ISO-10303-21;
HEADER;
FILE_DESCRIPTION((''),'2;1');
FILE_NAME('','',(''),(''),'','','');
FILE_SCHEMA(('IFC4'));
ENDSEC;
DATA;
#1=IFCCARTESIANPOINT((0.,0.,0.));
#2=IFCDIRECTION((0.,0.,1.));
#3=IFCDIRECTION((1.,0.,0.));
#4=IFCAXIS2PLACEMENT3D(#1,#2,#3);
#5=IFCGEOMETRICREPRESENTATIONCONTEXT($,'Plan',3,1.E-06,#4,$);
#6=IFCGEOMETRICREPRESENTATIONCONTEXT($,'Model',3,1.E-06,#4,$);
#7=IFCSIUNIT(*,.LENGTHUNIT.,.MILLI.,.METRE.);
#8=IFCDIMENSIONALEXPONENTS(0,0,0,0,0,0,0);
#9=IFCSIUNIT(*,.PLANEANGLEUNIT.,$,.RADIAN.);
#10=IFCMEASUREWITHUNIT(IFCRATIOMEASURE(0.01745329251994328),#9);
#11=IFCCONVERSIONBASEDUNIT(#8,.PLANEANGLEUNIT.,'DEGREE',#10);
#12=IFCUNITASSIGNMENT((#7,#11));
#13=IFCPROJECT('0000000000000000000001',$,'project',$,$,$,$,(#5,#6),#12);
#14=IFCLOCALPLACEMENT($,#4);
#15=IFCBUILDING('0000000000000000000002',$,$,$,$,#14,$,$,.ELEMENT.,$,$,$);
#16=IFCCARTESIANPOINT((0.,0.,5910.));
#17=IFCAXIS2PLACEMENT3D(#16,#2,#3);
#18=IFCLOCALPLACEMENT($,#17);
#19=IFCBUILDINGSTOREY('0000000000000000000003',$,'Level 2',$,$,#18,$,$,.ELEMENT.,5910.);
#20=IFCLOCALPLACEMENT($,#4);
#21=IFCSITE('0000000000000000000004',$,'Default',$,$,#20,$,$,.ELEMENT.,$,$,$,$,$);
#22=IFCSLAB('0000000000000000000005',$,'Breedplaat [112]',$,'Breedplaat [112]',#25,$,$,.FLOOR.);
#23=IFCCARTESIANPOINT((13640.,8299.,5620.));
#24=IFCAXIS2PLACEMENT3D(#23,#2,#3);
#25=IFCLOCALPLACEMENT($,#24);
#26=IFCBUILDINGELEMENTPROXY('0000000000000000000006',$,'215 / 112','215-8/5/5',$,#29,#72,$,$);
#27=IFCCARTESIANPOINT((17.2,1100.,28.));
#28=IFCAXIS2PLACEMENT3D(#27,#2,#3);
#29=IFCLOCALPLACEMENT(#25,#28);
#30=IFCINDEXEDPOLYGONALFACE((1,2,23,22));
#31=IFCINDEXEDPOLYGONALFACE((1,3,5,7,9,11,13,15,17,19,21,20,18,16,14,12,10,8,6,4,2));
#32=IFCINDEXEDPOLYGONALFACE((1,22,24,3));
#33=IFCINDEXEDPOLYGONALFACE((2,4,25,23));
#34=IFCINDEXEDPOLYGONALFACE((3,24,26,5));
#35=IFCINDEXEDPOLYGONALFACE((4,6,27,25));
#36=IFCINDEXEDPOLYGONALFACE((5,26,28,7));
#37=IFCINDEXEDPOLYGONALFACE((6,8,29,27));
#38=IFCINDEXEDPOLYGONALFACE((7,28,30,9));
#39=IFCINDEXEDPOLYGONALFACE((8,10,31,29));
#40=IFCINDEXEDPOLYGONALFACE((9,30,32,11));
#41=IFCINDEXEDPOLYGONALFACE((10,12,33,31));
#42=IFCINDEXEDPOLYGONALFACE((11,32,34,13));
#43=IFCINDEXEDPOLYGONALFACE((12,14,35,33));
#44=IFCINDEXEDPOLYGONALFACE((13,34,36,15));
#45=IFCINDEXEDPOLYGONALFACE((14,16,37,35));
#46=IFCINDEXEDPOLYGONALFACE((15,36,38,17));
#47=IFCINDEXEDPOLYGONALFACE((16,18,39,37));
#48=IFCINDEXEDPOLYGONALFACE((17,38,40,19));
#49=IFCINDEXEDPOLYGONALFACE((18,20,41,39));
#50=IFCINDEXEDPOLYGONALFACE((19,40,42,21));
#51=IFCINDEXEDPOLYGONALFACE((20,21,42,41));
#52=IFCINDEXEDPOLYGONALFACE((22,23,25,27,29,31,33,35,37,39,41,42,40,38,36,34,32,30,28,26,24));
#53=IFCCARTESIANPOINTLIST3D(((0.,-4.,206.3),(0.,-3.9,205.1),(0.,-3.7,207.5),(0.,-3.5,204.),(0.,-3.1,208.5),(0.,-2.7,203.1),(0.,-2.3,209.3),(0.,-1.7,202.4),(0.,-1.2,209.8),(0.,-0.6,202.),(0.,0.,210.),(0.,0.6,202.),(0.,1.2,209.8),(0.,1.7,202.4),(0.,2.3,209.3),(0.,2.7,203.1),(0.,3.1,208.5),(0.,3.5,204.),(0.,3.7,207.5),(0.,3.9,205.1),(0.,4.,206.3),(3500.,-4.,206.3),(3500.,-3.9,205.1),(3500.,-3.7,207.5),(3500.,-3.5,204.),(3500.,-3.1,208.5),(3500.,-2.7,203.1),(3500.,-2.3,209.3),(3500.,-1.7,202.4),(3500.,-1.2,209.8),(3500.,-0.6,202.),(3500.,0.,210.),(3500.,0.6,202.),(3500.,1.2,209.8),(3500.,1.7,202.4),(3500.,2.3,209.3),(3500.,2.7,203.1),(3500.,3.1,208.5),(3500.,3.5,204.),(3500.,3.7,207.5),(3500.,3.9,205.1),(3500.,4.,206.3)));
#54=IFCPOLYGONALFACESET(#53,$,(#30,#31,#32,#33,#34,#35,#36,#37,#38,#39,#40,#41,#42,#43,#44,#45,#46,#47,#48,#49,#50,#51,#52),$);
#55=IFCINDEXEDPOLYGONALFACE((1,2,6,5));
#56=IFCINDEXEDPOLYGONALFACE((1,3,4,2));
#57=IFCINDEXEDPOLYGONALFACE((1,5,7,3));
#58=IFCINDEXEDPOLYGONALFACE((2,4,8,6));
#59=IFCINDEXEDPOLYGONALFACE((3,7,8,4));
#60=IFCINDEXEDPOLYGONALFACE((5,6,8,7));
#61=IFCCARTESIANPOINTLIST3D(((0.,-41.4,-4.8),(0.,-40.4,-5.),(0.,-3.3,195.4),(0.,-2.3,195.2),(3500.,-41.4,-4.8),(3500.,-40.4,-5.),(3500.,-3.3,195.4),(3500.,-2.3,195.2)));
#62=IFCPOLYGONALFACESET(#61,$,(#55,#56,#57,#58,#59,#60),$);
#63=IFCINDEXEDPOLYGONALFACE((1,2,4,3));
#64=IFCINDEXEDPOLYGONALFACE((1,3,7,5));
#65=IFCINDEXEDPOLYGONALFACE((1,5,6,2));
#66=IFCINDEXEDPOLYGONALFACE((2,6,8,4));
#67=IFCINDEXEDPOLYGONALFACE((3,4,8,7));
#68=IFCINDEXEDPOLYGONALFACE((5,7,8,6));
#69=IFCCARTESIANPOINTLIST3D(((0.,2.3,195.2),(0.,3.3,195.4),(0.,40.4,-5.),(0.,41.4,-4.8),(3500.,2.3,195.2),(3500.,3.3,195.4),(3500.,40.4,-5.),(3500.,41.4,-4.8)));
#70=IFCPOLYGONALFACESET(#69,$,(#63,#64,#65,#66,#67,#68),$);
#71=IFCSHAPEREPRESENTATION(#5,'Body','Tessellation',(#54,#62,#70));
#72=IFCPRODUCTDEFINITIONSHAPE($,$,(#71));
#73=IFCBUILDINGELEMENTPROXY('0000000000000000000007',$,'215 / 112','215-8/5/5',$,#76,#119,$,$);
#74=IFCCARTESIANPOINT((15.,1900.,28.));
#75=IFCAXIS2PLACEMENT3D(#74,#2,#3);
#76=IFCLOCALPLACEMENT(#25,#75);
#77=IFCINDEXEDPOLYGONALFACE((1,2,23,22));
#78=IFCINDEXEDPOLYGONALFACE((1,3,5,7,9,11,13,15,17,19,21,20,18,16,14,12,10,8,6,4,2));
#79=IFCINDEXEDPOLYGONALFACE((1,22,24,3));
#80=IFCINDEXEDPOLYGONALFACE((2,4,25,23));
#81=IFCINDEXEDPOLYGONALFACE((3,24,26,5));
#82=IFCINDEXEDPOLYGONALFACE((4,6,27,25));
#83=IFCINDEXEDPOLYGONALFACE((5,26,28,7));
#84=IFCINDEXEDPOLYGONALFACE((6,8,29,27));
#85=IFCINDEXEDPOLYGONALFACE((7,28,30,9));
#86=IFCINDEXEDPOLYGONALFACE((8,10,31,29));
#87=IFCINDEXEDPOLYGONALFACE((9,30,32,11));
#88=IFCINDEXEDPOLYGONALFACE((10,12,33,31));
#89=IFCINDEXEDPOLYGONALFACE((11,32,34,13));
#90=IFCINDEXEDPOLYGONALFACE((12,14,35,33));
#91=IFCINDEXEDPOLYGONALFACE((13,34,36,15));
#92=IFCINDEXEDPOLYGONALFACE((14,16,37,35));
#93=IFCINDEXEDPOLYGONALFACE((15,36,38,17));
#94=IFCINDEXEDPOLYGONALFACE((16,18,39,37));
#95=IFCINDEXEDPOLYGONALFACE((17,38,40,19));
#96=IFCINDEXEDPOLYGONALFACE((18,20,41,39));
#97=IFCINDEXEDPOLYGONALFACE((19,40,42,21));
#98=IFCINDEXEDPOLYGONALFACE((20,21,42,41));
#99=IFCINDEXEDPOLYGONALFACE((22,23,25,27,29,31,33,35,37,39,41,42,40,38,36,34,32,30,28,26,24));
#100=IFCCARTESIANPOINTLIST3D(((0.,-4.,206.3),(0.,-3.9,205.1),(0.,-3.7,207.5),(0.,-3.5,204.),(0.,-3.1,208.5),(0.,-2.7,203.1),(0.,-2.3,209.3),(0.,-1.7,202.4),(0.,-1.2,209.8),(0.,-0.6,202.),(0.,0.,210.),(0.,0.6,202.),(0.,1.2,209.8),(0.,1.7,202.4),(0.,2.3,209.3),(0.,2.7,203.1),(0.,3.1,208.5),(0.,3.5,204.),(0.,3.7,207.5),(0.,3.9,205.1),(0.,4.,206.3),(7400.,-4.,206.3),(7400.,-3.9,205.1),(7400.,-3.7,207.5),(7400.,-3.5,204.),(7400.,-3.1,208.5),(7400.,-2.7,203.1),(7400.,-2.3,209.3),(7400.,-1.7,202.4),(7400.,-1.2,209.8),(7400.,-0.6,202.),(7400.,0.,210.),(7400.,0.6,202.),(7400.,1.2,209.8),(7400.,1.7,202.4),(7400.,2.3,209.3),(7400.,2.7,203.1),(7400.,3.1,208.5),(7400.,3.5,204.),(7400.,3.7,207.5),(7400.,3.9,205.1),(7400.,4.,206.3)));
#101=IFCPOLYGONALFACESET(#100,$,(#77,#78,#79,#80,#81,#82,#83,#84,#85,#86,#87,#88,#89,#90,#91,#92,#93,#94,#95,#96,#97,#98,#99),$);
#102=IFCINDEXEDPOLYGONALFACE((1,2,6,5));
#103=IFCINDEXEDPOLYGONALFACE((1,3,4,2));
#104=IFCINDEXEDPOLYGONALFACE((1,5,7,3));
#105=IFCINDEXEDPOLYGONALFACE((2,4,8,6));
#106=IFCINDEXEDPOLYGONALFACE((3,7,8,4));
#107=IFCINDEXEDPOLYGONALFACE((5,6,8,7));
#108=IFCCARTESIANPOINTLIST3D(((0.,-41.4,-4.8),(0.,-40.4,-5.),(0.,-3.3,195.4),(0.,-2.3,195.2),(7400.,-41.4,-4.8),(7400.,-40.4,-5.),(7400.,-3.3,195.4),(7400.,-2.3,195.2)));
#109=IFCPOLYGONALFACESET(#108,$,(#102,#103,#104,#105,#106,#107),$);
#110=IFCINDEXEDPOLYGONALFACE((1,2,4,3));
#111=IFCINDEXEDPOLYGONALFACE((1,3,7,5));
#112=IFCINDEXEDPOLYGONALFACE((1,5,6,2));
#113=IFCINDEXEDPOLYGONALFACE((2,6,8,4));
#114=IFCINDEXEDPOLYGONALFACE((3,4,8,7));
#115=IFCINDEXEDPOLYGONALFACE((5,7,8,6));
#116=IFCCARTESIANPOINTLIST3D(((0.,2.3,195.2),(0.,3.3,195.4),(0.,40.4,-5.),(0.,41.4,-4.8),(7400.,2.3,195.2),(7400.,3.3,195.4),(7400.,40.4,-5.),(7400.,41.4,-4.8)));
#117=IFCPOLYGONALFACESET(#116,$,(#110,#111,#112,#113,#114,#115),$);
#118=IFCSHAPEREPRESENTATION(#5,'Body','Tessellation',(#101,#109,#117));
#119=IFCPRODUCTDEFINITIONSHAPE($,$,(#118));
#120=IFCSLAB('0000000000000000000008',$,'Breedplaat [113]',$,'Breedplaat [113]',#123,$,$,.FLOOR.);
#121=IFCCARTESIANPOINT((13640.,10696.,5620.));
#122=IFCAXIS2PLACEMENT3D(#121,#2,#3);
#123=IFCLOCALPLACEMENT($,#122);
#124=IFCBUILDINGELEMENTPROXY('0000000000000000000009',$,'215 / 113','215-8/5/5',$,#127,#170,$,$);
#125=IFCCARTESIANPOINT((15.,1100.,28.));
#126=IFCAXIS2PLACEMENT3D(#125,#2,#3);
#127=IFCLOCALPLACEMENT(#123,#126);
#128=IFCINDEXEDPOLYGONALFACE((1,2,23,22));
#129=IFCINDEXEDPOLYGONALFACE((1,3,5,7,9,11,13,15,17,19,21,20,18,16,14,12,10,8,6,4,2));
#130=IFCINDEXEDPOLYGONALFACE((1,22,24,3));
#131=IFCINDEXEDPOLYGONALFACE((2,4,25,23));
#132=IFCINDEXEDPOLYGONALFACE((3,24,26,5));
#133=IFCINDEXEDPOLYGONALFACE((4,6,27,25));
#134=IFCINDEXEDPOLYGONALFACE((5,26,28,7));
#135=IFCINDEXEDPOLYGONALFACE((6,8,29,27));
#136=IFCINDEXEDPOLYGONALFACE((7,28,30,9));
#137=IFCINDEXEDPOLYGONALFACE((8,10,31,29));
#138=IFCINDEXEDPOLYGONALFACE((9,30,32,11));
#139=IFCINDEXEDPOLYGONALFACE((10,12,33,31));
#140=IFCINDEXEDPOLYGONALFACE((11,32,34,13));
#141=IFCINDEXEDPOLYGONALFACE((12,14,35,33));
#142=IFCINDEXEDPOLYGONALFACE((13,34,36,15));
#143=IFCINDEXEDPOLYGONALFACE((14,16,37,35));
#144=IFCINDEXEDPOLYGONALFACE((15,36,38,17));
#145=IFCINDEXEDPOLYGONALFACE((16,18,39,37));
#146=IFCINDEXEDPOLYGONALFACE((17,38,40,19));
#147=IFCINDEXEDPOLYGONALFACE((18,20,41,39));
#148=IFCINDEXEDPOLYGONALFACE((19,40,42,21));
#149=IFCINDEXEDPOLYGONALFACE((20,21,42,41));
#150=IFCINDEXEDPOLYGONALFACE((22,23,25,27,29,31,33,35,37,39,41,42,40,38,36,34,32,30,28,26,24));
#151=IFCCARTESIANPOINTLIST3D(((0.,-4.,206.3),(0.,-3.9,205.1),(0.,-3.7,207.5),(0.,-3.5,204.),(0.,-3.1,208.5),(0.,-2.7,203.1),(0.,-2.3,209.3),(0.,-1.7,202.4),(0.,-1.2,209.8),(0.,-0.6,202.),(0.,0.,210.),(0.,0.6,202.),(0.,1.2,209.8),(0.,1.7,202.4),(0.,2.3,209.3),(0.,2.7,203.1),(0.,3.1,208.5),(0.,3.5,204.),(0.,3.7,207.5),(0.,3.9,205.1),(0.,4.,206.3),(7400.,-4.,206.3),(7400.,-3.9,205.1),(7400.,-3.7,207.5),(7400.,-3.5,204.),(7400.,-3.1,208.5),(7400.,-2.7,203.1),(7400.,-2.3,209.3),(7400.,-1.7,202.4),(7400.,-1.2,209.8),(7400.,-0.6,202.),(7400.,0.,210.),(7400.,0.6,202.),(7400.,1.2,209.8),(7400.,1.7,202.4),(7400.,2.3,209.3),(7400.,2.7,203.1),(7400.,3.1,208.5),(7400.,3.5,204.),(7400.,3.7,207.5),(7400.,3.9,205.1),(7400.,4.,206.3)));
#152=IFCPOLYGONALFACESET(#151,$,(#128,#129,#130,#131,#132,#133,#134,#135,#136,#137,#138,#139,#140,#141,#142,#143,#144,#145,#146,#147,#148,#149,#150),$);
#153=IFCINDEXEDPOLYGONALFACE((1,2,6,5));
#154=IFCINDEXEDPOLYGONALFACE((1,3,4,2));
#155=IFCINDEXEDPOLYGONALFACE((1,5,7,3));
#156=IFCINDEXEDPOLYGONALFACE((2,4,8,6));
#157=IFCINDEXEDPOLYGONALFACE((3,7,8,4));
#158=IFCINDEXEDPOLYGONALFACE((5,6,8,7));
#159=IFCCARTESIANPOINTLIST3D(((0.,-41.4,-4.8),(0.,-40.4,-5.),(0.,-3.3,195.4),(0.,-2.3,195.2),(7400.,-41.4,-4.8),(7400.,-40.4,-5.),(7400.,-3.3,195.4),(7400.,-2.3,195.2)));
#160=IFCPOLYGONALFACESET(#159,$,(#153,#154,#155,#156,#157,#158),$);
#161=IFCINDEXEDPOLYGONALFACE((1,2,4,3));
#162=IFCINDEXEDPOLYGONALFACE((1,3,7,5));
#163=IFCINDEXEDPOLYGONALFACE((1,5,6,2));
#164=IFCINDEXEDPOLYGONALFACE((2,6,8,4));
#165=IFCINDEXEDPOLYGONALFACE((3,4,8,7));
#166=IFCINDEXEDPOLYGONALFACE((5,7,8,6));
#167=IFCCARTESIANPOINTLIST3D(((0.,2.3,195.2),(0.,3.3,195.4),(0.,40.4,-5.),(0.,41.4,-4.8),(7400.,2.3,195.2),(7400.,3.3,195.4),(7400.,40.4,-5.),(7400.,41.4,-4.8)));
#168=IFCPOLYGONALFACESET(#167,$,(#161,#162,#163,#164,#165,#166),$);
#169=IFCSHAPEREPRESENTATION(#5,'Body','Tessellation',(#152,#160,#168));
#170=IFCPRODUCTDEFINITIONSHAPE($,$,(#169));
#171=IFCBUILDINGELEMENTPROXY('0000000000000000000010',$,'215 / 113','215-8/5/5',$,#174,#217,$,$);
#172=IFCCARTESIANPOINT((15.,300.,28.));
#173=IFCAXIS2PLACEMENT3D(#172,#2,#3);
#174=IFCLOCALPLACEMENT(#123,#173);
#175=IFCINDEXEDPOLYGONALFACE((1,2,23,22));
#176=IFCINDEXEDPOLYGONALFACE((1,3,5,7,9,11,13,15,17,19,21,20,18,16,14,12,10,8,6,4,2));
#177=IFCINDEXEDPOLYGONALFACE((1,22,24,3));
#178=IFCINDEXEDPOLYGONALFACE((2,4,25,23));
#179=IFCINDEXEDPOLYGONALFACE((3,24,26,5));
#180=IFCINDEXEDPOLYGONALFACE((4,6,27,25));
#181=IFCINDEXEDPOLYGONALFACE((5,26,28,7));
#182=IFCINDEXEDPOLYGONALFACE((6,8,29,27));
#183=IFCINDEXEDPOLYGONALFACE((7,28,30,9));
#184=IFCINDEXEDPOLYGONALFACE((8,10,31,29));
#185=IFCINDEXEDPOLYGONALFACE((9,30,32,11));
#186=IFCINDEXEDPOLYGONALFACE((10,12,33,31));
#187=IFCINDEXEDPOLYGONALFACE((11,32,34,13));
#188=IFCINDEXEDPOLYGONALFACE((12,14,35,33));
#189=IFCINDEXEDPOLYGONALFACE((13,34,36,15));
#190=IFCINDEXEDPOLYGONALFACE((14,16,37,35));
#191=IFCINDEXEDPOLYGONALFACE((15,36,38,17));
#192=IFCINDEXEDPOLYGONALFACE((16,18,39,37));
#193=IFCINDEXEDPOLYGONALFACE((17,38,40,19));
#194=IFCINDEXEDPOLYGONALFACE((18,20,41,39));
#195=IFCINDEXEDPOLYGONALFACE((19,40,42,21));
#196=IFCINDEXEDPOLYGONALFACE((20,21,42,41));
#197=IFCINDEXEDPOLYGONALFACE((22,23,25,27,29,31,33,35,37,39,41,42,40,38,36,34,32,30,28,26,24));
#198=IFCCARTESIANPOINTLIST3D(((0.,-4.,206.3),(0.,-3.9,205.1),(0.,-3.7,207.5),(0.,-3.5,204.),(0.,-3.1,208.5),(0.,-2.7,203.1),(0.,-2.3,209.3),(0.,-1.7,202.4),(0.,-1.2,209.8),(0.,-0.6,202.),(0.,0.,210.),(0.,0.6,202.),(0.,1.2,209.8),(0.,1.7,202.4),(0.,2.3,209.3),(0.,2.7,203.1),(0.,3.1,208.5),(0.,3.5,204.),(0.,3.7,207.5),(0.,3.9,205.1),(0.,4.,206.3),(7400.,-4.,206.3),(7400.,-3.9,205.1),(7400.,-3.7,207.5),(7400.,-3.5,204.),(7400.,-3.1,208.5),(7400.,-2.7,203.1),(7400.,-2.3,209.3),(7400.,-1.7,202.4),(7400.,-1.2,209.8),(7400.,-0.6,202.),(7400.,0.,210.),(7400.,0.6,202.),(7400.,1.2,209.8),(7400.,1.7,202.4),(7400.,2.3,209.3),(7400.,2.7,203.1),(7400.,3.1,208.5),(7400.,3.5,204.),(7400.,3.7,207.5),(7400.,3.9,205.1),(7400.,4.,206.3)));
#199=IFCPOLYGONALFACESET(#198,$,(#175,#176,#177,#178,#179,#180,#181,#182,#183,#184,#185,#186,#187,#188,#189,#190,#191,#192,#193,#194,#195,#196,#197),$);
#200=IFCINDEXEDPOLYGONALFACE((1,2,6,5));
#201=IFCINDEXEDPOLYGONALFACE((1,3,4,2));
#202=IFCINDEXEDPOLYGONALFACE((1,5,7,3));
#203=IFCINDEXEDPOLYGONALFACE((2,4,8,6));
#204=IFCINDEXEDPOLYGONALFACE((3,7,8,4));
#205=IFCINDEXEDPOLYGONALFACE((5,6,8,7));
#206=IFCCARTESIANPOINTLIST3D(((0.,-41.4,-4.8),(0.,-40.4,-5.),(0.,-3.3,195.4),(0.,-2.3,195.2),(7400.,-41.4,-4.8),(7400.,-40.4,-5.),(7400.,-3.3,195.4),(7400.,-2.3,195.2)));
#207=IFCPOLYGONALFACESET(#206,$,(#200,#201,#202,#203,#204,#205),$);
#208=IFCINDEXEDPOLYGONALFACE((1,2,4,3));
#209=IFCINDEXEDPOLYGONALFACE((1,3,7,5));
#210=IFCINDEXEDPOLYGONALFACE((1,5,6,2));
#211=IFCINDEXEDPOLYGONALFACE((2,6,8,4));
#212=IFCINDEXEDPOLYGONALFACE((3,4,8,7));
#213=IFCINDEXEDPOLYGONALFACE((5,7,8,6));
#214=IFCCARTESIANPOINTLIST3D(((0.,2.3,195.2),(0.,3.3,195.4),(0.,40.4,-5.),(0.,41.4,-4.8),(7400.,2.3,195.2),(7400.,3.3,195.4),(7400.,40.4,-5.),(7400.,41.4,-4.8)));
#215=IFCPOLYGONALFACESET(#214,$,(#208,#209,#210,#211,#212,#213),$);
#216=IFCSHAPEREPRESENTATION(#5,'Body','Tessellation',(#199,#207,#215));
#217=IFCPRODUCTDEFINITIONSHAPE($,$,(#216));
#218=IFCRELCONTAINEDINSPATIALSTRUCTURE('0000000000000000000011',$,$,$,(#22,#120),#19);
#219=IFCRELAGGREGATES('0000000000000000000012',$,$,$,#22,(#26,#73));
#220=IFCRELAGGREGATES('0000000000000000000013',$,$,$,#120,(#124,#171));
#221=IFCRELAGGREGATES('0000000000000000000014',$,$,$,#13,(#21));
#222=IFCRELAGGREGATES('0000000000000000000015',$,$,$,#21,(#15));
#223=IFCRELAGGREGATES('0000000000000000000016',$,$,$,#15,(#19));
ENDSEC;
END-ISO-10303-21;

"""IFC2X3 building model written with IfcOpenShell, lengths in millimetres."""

from ifc_helpers import new_model, entity, si_unit, converted_unit, frame, origin_with_axes, origin_2d_with_axis, place, context, project, spatial, rectangle, circle, extrude, element, aggregate, save


model = new_model("IFC2X3")

# Units and contexts
plan_context = context("Plan", 3, precision=1e-06, world=origin_with_axes())
model_context = context("Model", 3, precision=1e-06, world=origin_with_axes())
ifc_project = project(units=[si_unit("LENGTHUNIT", "METRE", prefix="MILLI"), converted_unit("PLANEANGLEUNIT", "DEGREE", entity("IfcRatioMeasure", 0.01745329251994328), si_unit("PLANEANGLEUNIT", "RADIAN"), dimensions=[0, 0, 0, 0, 0, 0, 0])], contexts=[plan_context, model_context])

# Site, building, storey
site_placement = place(None, origin_with_axes())
site = spatial("IfcSite", under=ifc_project, at=site_placement, Name="Default", CompositionType="ELEMENT")
building_placement = place(None, origin_with_axes())
building = spatial("IfcBuilding", under=site, at=building_placement, CompositionType="ELEMENT")
storey_placement = place(None, frame((0.0, 0.0, 5910.0), z_axis=(0.0, 0.0, 1.0), x_axis=(1.0, 0.0, 0.0)))
storey = spatial("IfcBuildingStorey", under=building, at=storey_placement, Name="Level 2", CompositionType="ELEMENT", Elevation=5910.0)

# Slab, building element proxies
slab_1_placement = place(None, frame((13640.0, 8299.0, 5620.0), z_axis=(0.0, 0.0, 1.0), x_axis=(1.0, 0.0, 0.0)))
slab_1 = element("IfcSlab", 1, at=slab_1_placement, inside=storey, Name="Breedplaat [112]", ObjectType="Breedplaat [112]", PredefinedType="FLOOR")
proxy_1_placement = place(slab_1_placement, frame((17.2, 1100.0, 28.0), z_axis=(0.0, 0.0, 1.0), x_axis=(1.0, 0.0, 0.0)))
proxy_1 = element("IfcBuildingElementProxy", 2, at=proxy_1_placement, Name="215 / 112", Description="215-8/5/5", context=plan_context, shape_type="SweptSolid", body=[
    extrude(circle(Radius=4.0, at=origin_2d_with_axis()), frame((0.0, 0.0, 206.0), z_axis=(1.0, 0.0, 0.0), x_axis=(0.0, 0.0, 1.0)), (0.0, 0.0, 1.0), 3500.0),
    extrude(rectangle(XDim=203.8, YDim=1.0, at=origin_2d_with_axis()), frame((0.0, -21.9, 95.2), z_axis=(1.0, 0.0, 0.0), x_axis=(0.0, 0.187112, 0.982339)), (0.0, 0.0, 1.0), 3500.0),
    extrude(rectangle(XDim=203.8, YDim=1.0, at=origin_2d_with_axis()), frame((0.0, 21.9, 95.2), z_axis=(1.0, 0.0, 0.0), x_axis=(0.0, -0.187112, 0.982339)), (0.0, 0.0, 1.0), 3500.0),
])
proxy_2_placement = place(slab_1_placement, frame((15.0, 1900.0, 28.0), z_axis=(0.0, 0.0, 1.0), x_axis=(1.0, 0.0, 0.0)))
proxy_2 = element("IfcBuildingElementProxy", 3, at=proxy_2_placement, Name="215 / 112", Description="215-8/5/5", context=plan_context, shape_type="SweptSolid", body=[
    extrude(circle(Radius=4.0, at=origin_2d_with_axis()), frame((0.0, 0.0, 206.0), z_axis=(1.0, 0.0, 0.0), x_axis=(0.0, 0.0, 1.0)), (0.0, 0.0, 1.0), 7400.0),
    extrude(rectangle(XDim=203.8, YDim=1.0, at=origin_2d_with_axis()), frame((0.0, -21.9, 95.2), z_axis=(1.0, 0.0, 0.0), x_axis=(0.0, 0.187112, 0.982339)), (0.0, 0.0, 1.0), 7400.0),
    extrude(rectangle(XDim=203.8, YDim=1.0, at=origin_2d_with_axis()), frame((0.0, 21.9, 95.2), z_axis=(1.0, 0.0, 0.0), x_axis=(0.0, -0.187112, 0.982339)), (0.0, 0.0, 1.0), 7400.0),
])
aggregate(slab_1, [proxy_1, proxy_2])

# Slab, building element proxies
slab_2_placement = place(None, frame((13640.0, 10696.0, 5620.0), z_axis=(0.0, 0.0, 1.0), x_axis=(1.0, 0.0, 0.0)))
slab_2 = element("IfcSlab", 4, at=slab_2_placement, inside=storey, Name="Breedplaat [113]", ObjectType="Breedplaat [113]", PredefinedType="FLOOR")
proxy_3_placement = place(slab_2_placement, frame((15.0, 1100.0, 28.0), z_axis=(0.0, 0.0, 1.0), x_axis=(1.0, 0.0, 0.0)))
proxy_3 = element("IfcBuildingElementProxy", 5, at=proxy_3_placement, Name="215 / 113", Description="215-8/5/5", context=plan_context, shape_type="SweptSolid", body=[
    extrude(circle(Radius=4.0, at=origin_2d_with_axis()), frame((0.0, 0.0, 206.0), z_axis=(1.0, 0.0, 0.0), x_axis=(0.0, 0.0, 1.0)), (0.0, 0.0, 1.0), 7400.0),
    extrude(rectangle(XDim=203.8, YDim=1.0, at=origin_2d_with_axis()), frame((0.0, -21.9, 95.2), z_axis=(1.0, 0.0, 0.0), x_axis=(0.0, 0.187112, 0.982339)), (0.0, 0.0, 1.0), 7400.0),
    extrude(rectangle(XDim=203.8, YDim=1.0, at=origin_2d_with_axis()), frame((0.0, 21.9, 95.2), z_axis=(1.0, 0.0, 0.0), x_axis=(0.0, -0.187112, 0.982339)), (0.0, 0.0, 1.0), 7400.0),
])
proxy_4_placement = place(slab_2_placement, frame((15.0, 300.0, 28.0), z_axis=(0.0, 0.0, 1.0), x_axis=(1.0, 0.0, 0.0)))
proxy_4 = element("IfcBuildingElementProxy", 6, at=proxy_4_placement, Name="215 / 113", Description="215-8/5/5", context=plan_context, shape_type="SweptSolid", body=[
    extrude(circle(Radius=4.0, at=origin_2d_with_axis()), frame((0.0, 0.0, 206.0), z_axis=(1.0, 0.0, 0.0), x_axis=(0.0, 0.0, 1.0)), (0.0, 0.0, 1.0), 7400.0),
    extrude(rectangle(XDim=203.8, YDim=1.0, at=origin_2d_with_axis()), frame((0.0, -21.9, 95.2), z_axis=(1.0, 0.0, 0.0), x_axis=(0.0, 0.187112, 0.982339)), (0.0, 0.0, 1.0), 7400.0),
    extrude(rectangle(XDim=203.8, YDim=1.0, at=origin_2d_with_axis()), frame((0.0, 21.9, 95.2), z_axis=(1.0, 0.0, 0.0), x_axis=(0.0, -0.187112, 0.982339)), (0.0, 0.0, 1.0), 7400.0),
])
aggregate(slab_2, [proxy_3, proxy_4])

save(model, "model.ifc")
